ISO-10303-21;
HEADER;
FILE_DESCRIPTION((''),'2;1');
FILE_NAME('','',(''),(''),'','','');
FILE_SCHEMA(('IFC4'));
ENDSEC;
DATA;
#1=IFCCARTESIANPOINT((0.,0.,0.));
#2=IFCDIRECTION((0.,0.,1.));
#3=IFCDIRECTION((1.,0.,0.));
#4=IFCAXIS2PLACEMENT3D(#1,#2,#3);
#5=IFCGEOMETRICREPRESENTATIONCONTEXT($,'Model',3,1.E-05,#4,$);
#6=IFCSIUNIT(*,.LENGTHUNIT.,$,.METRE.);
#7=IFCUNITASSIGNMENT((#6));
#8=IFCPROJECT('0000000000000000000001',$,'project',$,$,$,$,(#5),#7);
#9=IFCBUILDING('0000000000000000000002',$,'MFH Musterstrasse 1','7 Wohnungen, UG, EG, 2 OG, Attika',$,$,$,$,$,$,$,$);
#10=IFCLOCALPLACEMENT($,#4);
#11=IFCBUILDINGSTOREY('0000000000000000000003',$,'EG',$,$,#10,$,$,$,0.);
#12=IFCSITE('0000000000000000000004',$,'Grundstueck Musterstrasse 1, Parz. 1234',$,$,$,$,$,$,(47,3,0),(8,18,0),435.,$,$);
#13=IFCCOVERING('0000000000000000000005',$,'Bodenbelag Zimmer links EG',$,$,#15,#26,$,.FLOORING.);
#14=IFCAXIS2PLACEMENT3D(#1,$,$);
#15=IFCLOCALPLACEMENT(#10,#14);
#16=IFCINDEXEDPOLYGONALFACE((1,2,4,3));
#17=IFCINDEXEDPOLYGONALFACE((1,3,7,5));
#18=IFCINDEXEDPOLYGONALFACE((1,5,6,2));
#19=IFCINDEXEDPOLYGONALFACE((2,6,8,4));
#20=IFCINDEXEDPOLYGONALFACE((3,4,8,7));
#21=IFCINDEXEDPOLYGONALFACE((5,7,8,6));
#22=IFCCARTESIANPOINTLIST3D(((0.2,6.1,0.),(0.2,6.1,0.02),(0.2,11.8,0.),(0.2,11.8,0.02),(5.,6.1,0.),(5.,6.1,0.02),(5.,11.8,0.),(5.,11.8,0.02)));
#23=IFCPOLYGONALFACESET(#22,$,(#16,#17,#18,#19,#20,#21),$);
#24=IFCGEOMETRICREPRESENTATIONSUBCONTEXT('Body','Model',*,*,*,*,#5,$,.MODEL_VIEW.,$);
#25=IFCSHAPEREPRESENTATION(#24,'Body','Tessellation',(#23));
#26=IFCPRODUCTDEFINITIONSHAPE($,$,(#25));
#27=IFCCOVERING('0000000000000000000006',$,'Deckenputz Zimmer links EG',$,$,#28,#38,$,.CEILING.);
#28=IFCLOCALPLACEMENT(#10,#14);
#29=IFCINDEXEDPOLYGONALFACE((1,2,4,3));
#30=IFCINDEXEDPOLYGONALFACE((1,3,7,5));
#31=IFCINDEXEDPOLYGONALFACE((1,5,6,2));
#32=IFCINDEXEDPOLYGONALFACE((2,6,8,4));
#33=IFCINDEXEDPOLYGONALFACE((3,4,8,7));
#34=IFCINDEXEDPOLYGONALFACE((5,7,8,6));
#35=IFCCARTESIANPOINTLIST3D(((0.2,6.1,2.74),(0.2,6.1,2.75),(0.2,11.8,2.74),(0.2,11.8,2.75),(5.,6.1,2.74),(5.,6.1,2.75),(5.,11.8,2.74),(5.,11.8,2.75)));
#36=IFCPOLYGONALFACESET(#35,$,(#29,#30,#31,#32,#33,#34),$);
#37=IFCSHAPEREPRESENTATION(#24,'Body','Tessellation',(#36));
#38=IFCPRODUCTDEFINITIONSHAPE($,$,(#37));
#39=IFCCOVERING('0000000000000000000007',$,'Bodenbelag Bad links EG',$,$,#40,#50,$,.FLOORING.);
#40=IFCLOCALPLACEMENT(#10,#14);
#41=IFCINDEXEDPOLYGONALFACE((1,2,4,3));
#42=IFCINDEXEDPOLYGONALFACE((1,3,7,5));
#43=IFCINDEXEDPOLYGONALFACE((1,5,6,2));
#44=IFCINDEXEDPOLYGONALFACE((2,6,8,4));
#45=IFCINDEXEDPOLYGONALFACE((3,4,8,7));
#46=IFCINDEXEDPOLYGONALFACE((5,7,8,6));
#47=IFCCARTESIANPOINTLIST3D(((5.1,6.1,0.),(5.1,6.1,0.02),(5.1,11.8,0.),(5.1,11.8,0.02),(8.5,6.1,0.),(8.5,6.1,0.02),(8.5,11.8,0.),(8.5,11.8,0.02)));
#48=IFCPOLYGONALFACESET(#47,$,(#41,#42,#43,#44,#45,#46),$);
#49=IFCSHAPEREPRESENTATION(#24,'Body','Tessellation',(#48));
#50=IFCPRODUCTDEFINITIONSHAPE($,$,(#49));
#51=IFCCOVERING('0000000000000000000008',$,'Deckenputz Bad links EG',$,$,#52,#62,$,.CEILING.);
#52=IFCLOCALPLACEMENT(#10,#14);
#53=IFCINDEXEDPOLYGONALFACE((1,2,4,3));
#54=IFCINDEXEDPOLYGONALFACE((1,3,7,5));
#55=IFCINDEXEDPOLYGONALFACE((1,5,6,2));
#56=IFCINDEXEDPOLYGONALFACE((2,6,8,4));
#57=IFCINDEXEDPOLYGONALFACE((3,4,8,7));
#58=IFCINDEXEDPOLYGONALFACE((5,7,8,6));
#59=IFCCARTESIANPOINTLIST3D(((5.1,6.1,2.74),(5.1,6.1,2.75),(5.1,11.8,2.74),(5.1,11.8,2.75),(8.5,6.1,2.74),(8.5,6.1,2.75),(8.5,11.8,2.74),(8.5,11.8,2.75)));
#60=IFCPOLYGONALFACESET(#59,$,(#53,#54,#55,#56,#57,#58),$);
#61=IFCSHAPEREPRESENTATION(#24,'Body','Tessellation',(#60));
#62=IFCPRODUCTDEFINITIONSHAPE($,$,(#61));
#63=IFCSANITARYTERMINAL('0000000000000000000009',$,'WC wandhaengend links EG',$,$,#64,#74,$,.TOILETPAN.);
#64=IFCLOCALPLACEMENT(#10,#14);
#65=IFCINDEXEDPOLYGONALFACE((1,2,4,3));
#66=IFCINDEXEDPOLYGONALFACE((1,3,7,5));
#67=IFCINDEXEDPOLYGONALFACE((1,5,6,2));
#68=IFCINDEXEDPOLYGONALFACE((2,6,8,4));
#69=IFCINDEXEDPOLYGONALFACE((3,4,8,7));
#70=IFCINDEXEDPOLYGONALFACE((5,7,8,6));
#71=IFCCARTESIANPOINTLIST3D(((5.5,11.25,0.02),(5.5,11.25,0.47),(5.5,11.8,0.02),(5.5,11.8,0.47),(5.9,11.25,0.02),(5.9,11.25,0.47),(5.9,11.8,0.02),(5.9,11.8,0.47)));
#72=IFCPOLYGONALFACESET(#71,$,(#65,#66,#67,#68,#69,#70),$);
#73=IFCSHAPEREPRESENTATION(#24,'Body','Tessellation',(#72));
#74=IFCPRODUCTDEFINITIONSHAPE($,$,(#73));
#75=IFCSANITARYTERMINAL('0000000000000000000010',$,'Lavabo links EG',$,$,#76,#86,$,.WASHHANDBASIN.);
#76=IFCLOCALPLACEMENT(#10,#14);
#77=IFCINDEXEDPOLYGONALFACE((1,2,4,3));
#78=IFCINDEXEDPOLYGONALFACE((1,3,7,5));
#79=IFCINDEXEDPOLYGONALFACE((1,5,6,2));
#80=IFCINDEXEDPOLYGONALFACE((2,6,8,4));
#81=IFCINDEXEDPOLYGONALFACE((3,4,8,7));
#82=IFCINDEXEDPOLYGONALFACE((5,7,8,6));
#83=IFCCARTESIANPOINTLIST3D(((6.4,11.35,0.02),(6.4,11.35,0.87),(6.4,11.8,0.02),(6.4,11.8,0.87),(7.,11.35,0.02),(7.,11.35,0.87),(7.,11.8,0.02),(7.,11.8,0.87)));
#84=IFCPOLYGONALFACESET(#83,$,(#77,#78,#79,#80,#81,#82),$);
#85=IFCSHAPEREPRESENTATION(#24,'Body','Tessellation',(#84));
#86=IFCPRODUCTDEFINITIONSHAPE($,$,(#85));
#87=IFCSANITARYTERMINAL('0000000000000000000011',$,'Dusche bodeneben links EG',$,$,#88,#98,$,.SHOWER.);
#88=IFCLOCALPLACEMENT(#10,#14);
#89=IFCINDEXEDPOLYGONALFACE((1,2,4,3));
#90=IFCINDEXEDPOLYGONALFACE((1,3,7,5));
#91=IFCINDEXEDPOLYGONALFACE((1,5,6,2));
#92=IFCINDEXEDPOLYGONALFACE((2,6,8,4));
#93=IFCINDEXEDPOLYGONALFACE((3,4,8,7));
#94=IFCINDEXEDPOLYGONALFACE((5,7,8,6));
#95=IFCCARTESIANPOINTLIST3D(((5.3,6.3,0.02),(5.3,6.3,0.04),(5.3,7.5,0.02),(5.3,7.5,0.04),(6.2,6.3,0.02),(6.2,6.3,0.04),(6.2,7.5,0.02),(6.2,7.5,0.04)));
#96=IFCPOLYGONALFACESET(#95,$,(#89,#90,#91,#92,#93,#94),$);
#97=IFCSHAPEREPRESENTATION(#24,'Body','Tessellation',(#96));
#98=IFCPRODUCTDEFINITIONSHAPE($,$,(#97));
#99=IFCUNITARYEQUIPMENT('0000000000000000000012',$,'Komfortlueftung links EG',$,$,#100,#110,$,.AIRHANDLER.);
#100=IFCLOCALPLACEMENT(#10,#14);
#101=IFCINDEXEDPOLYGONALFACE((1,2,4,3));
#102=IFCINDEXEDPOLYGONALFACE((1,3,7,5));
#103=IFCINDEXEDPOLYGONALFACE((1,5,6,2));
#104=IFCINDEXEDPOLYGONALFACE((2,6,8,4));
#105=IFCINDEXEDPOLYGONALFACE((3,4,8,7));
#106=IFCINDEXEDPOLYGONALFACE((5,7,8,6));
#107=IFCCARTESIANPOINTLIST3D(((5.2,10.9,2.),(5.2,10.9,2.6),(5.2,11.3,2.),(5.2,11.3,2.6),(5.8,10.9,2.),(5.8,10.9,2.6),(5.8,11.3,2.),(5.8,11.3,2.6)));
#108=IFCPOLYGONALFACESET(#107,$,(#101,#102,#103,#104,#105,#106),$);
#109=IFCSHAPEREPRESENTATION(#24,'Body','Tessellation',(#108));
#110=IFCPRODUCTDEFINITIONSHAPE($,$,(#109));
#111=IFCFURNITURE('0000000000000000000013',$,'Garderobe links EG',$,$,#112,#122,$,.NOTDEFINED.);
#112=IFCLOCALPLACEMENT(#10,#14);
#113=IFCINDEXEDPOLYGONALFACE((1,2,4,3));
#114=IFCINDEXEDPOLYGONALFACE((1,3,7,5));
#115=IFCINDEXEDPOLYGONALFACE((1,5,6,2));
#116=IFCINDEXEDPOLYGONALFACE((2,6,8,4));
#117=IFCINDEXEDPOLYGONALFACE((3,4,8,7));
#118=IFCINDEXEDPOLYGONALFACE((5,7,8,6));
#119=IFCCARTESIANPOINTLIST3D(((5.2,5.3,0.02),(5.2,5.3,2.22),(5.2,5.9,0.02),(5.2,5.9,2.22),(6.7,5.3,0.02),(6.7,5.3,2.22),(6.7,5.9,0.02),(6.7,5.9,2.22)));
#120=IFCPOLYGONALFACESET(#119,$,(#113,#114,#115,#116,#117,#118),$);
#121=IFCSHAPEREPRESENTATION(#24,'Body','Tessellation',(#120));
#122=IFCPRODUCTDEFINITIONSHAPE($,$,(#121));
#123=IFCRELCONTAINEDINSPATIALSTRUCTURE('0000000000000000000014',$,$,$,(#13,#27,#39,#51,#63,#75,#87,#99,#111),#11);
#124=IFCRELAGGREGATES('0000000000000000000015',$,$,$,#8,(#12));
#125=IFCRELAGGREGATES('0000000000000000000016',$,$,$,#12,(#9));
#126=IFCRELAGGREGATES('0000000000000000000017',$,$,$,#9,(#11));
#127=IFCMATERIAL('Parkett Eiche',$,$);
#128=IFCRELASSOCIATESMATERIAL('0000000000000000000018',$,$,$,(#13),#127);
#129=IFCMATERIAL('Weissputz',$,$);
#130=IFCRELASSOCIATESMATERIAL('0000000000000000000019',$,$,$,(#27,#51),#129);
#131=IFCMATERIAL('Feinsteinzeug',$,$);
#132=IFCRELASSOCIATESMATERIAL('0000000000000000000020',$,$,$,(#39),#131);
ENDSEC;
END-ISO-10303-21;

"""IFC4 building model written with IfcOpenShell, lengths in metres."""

from ifc_helpers import new_model, si_unit, frame, frame_2d, origin_with_axes, place, context, subcontext, project, spatial, rectangle, extrude, material, element, save


model = new_model("IFC4")

# Units and contexts
model_context = context("Model", 3, precision=1e-05, world=origin_with_axes())
body_context = subcontext(model_context, "Body", "Model", "MODEL_VIEW")
ifc_project = project(units=[si_unit("LENGTHUNIT", "METRE")], contexts=[model_context])

# Site, building, storey
site = spatial("IfcSite", under=ifc_project, Name="Grundstueck Musterstrasse 1, Parz. 1234", RefLatitude=(47, 3, 0), RefLongitude=(8, 18, 0), RefElevation=435.0)
building = spatial("IfcBuilding", under=site, Name="MFH Musterstrasse 1", Description="7 Wohnungen, UG, EG, 2 OG, Attika")
storey_placement = place(None, origin_with_axes())
storey = spatial("IfcBuildingStorey", under=building, at=storey_placement, Name="EG", Elevation=0.0)

# Coverings
ifc_material_1 = material(Name="Parkett Eiche")
covering_1_placement = place(storey_placement, frame((0.2, 6.1, 0.0), z_axis=(0.0, 0.0, 1.0), x_axis=(1.0, 0.0, 0.0)))
element("IfcCovering", 1, at=covering_1_placement, inside=storey, material=ifc_material_1, Name="Bodenbelag Zimmer links EG", PredefinedType="FLOORING", context=body_context, shape_type="SweptSolid", body=[
    extrude(rectangle(XDim=4.8, YDim=5.7, at=frame_2d((2.4, 2.85))), origin_with_axes(), (0.0, 0.0, 1.0), 0.02),
])
ifc_material_2 = material(Name="Weissputz")
covering_2_placement = place(storey_placement, frame((0.2, 6.1, 2.74), z_axis=(0.0, 0.0, 1.0), x_axis=(1.0, 0.0, 0.0)))
element("IfcCovering", 2, at=covering_2_placement, inside=storey, material=ifc_material_2, Name="Deckenputz Zimmer links EG", PredefinedType="CEILING", context=body_context, shape_type="SweptSolid", body=[
    extrude(rectangle(XDim=4.8, YDim=5.7, at=frame_2d((2.4, 2.85))), origin_with_axes(), (0.0, 0.0, 1.0), 0.01),
])
ifc_material_3 = material(Name="Feinsteinzeug")
covering_3_placement = place(storey_placement, frame((5.1, 6.1, 0.0), z_axis=(0.0, 0.0, 1.0), x_axis=(1.0, 0.0, 0.0)))
element("IfcCovering", 3, at=covering_3_placement, inside=storey, material=ifc_material_3, Name="Bodenbelag Bad links EG", PredefinedType="FLOORING", context=body_context, shape_type="SweptSolid", body=[
    extrude(rectangle(XDim=3.4, YDim=5.7, at=frame_2d((1.7, 2.85))), origin_with_axes(), (0.0, 0.0, 1.0), 0.02),
])
covering_4_placement = place(storey_placement, frame((5.1, 6.1, 2.74), z_axis=(0.0, 0.0, 1.0), x_axis=(1.0, 0.0, 0.0)))
element("IfcCovering", 4, at=covering_4_placement, inside=storey, material=ifc_material_2, Name="Deckenputz Bad links EG", PredefinedType="CEILING", context=body_context, shape_type="SweptSolid", body=[
    extrude(rectangle(XDim=3.4, YDim=5.7, at=frame_2d((1.7, 2.85))), origin_with_axes(), (0.0, 0.0, 1.0), 0.01),
])

# Sanitary terminals
sanitary_terminal_1_placement = place(storey_placement, frame((5.5, 11.25, 0.02), z_axis=(0.0, 0.0, 1.0), x_axis=(1.0, 0.0, 0.0)))
element("IfcSanitaryTerminal", 5, at=sanitary_terminal_1_placement, inside=storey, Name="WC wandhaengend links EG", PredefinedType="TOILETPAN", context=body_context, shape_type="SweptSolid", body=[
    extrude(rectangle(XDim=0.4, YDim=0.55, at=frame_2d((0.2, 0.275))), origin_with_axes(), (0.0, 0.0, 1.0), 0.45),
])
sanitary_terminal_2_placement = place(storey_placement, frame((6.4, 11.35, 0.02), z_axis=(0.0, 0.0, 1.0), x_axis=(1.0, 0.0, 0.0)))
element("IfcSanitaryTerminal", 6, at=sanitary_terminal_2_placement, inside=storey, Name="Lavabo links EG", PredefinedType="WASHHANDBASIN", context=body_context, shape_type="SweptSolid", body=[
    extrude(rectangle(XDim=0.6, YDim=0.45, at=frame_2d((0.3, 0.225))), origin_with_axes(), (0.0, 0.0, 1.0), 0.85),
])
sanitary_terminal_3_placement = place(storey_placement, frame((5.3, 6.3, 0.02), z_axis=(0.0, 0.0, 1.0), x_axis=(1.0, 0.0, 0.0)))
element("IfcSanitaryTerminal", 7, at=sanitary_terminal_3_placement, inside=storey, Name="Dusche bodeneben links EG", PredefinedType="SHOWER", context=body_context, shape_type="SweptSolid", body=[
    extrude(rectangle(XDim=0.9, YDim=1.2, at=frame_2d((0.45, 0.6))), origin_with_axes(), (0.0, 0.0, 1.0), 0.02),
])

# Unitary equipment
unitary_equipment_placement = place(storey_placement, frame((5.2, 10.9, 2.0), z_axis=(0.0, 0.0, 1.0), x_axis=(1.0, 0.0, 0.0)))
element("IfcUnitaryEquipment", 8, at=unitary_equipment_placement, inside=storey, Name="Komfortlueftung links EG", PredefinedType="AIRHANDLER", context=body_context, shape_type="SweptSolid", body=[
    extrude(rectangle(XDim=0.6, YDim=0.4, at=frame_2d((0.3, 0.2))), origin_with_axes(), (0.0, 0.0, 1.0), 0.6),
])

# Furniture
furniture_placement = place(storey_placement, frame((5.2, 5.3, 0.02), z_axis=(0.0, 0.0, 1.0), x_axis=(1.0, 0.0, 0.0)))
element("IfcFurniture", 9, at=furniture_placement, inside=storey, Name="Garderobe links EG", PredefinedType="NOTDEFINED", context=body_context, shape_type="SweptSolid", body=[
    extrude(rectangle(XDim=1.5, YDim=0.6, at=frame_2d((0.75, 0.3))), origin_with_axes(), (0.0, 0.0, 1.0), 2.2),
])

save(model, "model.ifc")
